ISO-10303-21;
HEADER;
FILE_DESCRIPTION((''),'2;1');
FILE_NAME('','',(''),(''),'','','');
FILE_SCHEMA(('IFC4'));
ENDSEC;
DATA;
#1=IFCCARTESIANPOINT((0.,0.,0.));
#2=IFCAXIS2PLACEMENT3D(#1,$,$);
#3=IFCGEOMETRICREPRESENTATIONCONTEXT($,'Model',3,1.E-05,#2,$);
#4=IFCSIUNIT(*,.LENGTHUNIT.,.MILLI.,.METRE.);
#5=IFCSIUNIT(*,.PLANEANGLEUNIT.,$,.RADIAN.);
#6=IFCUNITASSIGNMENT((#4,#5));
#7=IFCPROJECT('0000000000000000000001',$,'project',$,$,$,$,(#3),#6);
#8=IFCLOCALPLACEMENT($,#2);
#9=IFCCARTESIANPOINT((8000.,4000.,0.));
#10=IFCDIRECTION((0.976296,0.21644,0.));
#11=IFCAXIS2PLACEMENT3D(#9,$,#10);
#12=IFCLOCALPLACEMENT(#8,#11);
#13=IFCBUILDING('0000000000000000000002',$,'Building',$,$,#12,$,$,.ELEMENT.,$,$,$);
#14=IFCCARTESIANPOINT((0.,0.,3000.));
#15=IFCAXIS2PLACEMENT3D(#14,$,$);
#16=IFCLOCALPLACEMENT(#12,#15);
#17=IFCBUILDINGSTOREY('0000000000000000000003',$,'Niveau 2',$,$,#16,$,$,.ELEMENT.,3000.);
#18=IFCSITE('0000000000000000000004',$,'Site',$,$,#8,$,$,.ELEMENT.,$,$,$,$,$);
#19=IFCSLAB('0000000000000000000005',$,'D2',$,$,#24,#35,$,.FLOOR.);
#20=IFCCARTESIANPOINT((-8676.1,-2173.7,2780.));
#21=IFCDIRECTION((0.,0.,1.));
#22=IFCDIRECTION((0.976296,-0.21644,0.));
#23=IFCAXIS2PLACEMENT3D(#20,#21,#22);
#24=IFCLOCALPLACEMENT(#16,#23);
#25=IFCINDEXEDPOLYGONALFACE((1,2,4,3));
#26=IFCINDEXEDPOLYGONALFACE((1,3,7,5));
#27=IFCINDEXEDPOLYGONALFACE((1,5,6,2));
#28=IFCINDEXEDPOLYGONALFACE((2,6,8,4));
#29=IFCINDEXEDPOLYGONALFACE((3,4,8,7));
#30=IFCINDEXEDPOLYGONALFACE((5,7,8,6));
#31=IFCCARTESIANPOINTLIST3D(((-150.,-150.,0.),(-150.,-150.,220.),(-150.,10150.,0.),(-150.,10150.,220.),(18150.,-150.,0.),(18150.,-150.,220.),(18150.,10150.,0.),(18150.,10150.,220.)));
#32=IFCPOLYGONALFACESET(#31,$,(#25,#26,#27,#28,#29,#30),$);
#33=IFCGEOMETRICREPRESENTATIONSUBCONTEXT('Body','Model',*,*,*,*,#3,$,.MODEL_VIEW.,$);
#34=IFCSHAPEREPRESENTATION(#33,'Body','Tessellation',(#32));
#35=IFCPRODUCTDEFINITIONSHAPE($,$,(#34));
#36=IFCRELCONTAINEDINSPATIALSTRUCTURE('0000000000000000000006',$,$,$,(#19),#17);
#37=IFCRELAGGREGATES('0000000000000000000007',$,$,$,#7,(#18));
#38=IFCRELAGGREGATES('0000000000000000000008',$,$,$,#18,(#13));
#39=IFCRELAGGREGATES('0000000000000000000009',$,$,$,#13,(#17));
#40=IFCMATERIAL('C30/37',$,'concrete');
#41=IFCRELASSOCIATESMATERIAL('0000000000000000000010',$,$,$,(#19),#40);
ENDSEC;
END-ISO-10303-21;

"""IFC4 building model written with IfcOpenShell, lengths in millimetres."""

from ifc_helpers import new_model, si_unit, frame, origin, place, context, subcontext, project, spatial, polyline, outline, extrude, material, element, save


model = new_model("IFC4")

# Units and contexts
model_context = context("Model", 3, precision=1e-05, world=origin())
body_context = subcontext(model_context, "Body", "Model", "MODEL_VIEW")
ifc_project = project(units=[si_unit("LENGTHUNIT", "METRE", prefix="MILLI"), si_unit("PLANEANGLEUNIT", "RADIAN")], contexts=[model_context])

# Site, building, storey
site_placement = place(None, origin())
site = spatial("IfcSite", under=ifc_project, at=site_placement, Name="Site", CompositionType="ELEMENT")
building_placement = place(site_placement, frame((8000.0, 4000.0, 0.0), x_axis=(0.976296, 0.21644, 0.0)))
building = spatial("IfcBuilding", under=site, at=building_placement, Name="Building", CompositionType="ELEMENT")
storey_placement = place(building_placement, frame((0.0, 0.0, 3000.0)))
storey = spatial("IfcBuildingStorey", under=building, at=storey_placement, Name="Niveau 2", CompositionType="ELEMENT", Elevation=3000.0)

# Shared definitions
ifc_material = material(Name="C30/37", Category="concrete")

# Slab
slab_placement = place(storey_placement, frame((-8676.1, -2173.7, 2780.0), z_axis=(0.0, 0.0, 1.0), x_axis=(0.976296, -0.21644, 0.0)))
element("IfcSlab", 1, at=slab_placement, inside=storey, material=ifc_material, Name="D2", PredefinedType="FLOOR", context=body_context, shape_type="SweptSolid", body=[
    extrude(outline(polyline([(-150.0, -150.0), (18150.0, -150.0), (18150.0, 10150.0), (-150.0, 10150.0), (-150.0, -150.0)])), origin(), (0.0, 0.0, 1.0), 220.0),
])

save(model, "model.ifc")
